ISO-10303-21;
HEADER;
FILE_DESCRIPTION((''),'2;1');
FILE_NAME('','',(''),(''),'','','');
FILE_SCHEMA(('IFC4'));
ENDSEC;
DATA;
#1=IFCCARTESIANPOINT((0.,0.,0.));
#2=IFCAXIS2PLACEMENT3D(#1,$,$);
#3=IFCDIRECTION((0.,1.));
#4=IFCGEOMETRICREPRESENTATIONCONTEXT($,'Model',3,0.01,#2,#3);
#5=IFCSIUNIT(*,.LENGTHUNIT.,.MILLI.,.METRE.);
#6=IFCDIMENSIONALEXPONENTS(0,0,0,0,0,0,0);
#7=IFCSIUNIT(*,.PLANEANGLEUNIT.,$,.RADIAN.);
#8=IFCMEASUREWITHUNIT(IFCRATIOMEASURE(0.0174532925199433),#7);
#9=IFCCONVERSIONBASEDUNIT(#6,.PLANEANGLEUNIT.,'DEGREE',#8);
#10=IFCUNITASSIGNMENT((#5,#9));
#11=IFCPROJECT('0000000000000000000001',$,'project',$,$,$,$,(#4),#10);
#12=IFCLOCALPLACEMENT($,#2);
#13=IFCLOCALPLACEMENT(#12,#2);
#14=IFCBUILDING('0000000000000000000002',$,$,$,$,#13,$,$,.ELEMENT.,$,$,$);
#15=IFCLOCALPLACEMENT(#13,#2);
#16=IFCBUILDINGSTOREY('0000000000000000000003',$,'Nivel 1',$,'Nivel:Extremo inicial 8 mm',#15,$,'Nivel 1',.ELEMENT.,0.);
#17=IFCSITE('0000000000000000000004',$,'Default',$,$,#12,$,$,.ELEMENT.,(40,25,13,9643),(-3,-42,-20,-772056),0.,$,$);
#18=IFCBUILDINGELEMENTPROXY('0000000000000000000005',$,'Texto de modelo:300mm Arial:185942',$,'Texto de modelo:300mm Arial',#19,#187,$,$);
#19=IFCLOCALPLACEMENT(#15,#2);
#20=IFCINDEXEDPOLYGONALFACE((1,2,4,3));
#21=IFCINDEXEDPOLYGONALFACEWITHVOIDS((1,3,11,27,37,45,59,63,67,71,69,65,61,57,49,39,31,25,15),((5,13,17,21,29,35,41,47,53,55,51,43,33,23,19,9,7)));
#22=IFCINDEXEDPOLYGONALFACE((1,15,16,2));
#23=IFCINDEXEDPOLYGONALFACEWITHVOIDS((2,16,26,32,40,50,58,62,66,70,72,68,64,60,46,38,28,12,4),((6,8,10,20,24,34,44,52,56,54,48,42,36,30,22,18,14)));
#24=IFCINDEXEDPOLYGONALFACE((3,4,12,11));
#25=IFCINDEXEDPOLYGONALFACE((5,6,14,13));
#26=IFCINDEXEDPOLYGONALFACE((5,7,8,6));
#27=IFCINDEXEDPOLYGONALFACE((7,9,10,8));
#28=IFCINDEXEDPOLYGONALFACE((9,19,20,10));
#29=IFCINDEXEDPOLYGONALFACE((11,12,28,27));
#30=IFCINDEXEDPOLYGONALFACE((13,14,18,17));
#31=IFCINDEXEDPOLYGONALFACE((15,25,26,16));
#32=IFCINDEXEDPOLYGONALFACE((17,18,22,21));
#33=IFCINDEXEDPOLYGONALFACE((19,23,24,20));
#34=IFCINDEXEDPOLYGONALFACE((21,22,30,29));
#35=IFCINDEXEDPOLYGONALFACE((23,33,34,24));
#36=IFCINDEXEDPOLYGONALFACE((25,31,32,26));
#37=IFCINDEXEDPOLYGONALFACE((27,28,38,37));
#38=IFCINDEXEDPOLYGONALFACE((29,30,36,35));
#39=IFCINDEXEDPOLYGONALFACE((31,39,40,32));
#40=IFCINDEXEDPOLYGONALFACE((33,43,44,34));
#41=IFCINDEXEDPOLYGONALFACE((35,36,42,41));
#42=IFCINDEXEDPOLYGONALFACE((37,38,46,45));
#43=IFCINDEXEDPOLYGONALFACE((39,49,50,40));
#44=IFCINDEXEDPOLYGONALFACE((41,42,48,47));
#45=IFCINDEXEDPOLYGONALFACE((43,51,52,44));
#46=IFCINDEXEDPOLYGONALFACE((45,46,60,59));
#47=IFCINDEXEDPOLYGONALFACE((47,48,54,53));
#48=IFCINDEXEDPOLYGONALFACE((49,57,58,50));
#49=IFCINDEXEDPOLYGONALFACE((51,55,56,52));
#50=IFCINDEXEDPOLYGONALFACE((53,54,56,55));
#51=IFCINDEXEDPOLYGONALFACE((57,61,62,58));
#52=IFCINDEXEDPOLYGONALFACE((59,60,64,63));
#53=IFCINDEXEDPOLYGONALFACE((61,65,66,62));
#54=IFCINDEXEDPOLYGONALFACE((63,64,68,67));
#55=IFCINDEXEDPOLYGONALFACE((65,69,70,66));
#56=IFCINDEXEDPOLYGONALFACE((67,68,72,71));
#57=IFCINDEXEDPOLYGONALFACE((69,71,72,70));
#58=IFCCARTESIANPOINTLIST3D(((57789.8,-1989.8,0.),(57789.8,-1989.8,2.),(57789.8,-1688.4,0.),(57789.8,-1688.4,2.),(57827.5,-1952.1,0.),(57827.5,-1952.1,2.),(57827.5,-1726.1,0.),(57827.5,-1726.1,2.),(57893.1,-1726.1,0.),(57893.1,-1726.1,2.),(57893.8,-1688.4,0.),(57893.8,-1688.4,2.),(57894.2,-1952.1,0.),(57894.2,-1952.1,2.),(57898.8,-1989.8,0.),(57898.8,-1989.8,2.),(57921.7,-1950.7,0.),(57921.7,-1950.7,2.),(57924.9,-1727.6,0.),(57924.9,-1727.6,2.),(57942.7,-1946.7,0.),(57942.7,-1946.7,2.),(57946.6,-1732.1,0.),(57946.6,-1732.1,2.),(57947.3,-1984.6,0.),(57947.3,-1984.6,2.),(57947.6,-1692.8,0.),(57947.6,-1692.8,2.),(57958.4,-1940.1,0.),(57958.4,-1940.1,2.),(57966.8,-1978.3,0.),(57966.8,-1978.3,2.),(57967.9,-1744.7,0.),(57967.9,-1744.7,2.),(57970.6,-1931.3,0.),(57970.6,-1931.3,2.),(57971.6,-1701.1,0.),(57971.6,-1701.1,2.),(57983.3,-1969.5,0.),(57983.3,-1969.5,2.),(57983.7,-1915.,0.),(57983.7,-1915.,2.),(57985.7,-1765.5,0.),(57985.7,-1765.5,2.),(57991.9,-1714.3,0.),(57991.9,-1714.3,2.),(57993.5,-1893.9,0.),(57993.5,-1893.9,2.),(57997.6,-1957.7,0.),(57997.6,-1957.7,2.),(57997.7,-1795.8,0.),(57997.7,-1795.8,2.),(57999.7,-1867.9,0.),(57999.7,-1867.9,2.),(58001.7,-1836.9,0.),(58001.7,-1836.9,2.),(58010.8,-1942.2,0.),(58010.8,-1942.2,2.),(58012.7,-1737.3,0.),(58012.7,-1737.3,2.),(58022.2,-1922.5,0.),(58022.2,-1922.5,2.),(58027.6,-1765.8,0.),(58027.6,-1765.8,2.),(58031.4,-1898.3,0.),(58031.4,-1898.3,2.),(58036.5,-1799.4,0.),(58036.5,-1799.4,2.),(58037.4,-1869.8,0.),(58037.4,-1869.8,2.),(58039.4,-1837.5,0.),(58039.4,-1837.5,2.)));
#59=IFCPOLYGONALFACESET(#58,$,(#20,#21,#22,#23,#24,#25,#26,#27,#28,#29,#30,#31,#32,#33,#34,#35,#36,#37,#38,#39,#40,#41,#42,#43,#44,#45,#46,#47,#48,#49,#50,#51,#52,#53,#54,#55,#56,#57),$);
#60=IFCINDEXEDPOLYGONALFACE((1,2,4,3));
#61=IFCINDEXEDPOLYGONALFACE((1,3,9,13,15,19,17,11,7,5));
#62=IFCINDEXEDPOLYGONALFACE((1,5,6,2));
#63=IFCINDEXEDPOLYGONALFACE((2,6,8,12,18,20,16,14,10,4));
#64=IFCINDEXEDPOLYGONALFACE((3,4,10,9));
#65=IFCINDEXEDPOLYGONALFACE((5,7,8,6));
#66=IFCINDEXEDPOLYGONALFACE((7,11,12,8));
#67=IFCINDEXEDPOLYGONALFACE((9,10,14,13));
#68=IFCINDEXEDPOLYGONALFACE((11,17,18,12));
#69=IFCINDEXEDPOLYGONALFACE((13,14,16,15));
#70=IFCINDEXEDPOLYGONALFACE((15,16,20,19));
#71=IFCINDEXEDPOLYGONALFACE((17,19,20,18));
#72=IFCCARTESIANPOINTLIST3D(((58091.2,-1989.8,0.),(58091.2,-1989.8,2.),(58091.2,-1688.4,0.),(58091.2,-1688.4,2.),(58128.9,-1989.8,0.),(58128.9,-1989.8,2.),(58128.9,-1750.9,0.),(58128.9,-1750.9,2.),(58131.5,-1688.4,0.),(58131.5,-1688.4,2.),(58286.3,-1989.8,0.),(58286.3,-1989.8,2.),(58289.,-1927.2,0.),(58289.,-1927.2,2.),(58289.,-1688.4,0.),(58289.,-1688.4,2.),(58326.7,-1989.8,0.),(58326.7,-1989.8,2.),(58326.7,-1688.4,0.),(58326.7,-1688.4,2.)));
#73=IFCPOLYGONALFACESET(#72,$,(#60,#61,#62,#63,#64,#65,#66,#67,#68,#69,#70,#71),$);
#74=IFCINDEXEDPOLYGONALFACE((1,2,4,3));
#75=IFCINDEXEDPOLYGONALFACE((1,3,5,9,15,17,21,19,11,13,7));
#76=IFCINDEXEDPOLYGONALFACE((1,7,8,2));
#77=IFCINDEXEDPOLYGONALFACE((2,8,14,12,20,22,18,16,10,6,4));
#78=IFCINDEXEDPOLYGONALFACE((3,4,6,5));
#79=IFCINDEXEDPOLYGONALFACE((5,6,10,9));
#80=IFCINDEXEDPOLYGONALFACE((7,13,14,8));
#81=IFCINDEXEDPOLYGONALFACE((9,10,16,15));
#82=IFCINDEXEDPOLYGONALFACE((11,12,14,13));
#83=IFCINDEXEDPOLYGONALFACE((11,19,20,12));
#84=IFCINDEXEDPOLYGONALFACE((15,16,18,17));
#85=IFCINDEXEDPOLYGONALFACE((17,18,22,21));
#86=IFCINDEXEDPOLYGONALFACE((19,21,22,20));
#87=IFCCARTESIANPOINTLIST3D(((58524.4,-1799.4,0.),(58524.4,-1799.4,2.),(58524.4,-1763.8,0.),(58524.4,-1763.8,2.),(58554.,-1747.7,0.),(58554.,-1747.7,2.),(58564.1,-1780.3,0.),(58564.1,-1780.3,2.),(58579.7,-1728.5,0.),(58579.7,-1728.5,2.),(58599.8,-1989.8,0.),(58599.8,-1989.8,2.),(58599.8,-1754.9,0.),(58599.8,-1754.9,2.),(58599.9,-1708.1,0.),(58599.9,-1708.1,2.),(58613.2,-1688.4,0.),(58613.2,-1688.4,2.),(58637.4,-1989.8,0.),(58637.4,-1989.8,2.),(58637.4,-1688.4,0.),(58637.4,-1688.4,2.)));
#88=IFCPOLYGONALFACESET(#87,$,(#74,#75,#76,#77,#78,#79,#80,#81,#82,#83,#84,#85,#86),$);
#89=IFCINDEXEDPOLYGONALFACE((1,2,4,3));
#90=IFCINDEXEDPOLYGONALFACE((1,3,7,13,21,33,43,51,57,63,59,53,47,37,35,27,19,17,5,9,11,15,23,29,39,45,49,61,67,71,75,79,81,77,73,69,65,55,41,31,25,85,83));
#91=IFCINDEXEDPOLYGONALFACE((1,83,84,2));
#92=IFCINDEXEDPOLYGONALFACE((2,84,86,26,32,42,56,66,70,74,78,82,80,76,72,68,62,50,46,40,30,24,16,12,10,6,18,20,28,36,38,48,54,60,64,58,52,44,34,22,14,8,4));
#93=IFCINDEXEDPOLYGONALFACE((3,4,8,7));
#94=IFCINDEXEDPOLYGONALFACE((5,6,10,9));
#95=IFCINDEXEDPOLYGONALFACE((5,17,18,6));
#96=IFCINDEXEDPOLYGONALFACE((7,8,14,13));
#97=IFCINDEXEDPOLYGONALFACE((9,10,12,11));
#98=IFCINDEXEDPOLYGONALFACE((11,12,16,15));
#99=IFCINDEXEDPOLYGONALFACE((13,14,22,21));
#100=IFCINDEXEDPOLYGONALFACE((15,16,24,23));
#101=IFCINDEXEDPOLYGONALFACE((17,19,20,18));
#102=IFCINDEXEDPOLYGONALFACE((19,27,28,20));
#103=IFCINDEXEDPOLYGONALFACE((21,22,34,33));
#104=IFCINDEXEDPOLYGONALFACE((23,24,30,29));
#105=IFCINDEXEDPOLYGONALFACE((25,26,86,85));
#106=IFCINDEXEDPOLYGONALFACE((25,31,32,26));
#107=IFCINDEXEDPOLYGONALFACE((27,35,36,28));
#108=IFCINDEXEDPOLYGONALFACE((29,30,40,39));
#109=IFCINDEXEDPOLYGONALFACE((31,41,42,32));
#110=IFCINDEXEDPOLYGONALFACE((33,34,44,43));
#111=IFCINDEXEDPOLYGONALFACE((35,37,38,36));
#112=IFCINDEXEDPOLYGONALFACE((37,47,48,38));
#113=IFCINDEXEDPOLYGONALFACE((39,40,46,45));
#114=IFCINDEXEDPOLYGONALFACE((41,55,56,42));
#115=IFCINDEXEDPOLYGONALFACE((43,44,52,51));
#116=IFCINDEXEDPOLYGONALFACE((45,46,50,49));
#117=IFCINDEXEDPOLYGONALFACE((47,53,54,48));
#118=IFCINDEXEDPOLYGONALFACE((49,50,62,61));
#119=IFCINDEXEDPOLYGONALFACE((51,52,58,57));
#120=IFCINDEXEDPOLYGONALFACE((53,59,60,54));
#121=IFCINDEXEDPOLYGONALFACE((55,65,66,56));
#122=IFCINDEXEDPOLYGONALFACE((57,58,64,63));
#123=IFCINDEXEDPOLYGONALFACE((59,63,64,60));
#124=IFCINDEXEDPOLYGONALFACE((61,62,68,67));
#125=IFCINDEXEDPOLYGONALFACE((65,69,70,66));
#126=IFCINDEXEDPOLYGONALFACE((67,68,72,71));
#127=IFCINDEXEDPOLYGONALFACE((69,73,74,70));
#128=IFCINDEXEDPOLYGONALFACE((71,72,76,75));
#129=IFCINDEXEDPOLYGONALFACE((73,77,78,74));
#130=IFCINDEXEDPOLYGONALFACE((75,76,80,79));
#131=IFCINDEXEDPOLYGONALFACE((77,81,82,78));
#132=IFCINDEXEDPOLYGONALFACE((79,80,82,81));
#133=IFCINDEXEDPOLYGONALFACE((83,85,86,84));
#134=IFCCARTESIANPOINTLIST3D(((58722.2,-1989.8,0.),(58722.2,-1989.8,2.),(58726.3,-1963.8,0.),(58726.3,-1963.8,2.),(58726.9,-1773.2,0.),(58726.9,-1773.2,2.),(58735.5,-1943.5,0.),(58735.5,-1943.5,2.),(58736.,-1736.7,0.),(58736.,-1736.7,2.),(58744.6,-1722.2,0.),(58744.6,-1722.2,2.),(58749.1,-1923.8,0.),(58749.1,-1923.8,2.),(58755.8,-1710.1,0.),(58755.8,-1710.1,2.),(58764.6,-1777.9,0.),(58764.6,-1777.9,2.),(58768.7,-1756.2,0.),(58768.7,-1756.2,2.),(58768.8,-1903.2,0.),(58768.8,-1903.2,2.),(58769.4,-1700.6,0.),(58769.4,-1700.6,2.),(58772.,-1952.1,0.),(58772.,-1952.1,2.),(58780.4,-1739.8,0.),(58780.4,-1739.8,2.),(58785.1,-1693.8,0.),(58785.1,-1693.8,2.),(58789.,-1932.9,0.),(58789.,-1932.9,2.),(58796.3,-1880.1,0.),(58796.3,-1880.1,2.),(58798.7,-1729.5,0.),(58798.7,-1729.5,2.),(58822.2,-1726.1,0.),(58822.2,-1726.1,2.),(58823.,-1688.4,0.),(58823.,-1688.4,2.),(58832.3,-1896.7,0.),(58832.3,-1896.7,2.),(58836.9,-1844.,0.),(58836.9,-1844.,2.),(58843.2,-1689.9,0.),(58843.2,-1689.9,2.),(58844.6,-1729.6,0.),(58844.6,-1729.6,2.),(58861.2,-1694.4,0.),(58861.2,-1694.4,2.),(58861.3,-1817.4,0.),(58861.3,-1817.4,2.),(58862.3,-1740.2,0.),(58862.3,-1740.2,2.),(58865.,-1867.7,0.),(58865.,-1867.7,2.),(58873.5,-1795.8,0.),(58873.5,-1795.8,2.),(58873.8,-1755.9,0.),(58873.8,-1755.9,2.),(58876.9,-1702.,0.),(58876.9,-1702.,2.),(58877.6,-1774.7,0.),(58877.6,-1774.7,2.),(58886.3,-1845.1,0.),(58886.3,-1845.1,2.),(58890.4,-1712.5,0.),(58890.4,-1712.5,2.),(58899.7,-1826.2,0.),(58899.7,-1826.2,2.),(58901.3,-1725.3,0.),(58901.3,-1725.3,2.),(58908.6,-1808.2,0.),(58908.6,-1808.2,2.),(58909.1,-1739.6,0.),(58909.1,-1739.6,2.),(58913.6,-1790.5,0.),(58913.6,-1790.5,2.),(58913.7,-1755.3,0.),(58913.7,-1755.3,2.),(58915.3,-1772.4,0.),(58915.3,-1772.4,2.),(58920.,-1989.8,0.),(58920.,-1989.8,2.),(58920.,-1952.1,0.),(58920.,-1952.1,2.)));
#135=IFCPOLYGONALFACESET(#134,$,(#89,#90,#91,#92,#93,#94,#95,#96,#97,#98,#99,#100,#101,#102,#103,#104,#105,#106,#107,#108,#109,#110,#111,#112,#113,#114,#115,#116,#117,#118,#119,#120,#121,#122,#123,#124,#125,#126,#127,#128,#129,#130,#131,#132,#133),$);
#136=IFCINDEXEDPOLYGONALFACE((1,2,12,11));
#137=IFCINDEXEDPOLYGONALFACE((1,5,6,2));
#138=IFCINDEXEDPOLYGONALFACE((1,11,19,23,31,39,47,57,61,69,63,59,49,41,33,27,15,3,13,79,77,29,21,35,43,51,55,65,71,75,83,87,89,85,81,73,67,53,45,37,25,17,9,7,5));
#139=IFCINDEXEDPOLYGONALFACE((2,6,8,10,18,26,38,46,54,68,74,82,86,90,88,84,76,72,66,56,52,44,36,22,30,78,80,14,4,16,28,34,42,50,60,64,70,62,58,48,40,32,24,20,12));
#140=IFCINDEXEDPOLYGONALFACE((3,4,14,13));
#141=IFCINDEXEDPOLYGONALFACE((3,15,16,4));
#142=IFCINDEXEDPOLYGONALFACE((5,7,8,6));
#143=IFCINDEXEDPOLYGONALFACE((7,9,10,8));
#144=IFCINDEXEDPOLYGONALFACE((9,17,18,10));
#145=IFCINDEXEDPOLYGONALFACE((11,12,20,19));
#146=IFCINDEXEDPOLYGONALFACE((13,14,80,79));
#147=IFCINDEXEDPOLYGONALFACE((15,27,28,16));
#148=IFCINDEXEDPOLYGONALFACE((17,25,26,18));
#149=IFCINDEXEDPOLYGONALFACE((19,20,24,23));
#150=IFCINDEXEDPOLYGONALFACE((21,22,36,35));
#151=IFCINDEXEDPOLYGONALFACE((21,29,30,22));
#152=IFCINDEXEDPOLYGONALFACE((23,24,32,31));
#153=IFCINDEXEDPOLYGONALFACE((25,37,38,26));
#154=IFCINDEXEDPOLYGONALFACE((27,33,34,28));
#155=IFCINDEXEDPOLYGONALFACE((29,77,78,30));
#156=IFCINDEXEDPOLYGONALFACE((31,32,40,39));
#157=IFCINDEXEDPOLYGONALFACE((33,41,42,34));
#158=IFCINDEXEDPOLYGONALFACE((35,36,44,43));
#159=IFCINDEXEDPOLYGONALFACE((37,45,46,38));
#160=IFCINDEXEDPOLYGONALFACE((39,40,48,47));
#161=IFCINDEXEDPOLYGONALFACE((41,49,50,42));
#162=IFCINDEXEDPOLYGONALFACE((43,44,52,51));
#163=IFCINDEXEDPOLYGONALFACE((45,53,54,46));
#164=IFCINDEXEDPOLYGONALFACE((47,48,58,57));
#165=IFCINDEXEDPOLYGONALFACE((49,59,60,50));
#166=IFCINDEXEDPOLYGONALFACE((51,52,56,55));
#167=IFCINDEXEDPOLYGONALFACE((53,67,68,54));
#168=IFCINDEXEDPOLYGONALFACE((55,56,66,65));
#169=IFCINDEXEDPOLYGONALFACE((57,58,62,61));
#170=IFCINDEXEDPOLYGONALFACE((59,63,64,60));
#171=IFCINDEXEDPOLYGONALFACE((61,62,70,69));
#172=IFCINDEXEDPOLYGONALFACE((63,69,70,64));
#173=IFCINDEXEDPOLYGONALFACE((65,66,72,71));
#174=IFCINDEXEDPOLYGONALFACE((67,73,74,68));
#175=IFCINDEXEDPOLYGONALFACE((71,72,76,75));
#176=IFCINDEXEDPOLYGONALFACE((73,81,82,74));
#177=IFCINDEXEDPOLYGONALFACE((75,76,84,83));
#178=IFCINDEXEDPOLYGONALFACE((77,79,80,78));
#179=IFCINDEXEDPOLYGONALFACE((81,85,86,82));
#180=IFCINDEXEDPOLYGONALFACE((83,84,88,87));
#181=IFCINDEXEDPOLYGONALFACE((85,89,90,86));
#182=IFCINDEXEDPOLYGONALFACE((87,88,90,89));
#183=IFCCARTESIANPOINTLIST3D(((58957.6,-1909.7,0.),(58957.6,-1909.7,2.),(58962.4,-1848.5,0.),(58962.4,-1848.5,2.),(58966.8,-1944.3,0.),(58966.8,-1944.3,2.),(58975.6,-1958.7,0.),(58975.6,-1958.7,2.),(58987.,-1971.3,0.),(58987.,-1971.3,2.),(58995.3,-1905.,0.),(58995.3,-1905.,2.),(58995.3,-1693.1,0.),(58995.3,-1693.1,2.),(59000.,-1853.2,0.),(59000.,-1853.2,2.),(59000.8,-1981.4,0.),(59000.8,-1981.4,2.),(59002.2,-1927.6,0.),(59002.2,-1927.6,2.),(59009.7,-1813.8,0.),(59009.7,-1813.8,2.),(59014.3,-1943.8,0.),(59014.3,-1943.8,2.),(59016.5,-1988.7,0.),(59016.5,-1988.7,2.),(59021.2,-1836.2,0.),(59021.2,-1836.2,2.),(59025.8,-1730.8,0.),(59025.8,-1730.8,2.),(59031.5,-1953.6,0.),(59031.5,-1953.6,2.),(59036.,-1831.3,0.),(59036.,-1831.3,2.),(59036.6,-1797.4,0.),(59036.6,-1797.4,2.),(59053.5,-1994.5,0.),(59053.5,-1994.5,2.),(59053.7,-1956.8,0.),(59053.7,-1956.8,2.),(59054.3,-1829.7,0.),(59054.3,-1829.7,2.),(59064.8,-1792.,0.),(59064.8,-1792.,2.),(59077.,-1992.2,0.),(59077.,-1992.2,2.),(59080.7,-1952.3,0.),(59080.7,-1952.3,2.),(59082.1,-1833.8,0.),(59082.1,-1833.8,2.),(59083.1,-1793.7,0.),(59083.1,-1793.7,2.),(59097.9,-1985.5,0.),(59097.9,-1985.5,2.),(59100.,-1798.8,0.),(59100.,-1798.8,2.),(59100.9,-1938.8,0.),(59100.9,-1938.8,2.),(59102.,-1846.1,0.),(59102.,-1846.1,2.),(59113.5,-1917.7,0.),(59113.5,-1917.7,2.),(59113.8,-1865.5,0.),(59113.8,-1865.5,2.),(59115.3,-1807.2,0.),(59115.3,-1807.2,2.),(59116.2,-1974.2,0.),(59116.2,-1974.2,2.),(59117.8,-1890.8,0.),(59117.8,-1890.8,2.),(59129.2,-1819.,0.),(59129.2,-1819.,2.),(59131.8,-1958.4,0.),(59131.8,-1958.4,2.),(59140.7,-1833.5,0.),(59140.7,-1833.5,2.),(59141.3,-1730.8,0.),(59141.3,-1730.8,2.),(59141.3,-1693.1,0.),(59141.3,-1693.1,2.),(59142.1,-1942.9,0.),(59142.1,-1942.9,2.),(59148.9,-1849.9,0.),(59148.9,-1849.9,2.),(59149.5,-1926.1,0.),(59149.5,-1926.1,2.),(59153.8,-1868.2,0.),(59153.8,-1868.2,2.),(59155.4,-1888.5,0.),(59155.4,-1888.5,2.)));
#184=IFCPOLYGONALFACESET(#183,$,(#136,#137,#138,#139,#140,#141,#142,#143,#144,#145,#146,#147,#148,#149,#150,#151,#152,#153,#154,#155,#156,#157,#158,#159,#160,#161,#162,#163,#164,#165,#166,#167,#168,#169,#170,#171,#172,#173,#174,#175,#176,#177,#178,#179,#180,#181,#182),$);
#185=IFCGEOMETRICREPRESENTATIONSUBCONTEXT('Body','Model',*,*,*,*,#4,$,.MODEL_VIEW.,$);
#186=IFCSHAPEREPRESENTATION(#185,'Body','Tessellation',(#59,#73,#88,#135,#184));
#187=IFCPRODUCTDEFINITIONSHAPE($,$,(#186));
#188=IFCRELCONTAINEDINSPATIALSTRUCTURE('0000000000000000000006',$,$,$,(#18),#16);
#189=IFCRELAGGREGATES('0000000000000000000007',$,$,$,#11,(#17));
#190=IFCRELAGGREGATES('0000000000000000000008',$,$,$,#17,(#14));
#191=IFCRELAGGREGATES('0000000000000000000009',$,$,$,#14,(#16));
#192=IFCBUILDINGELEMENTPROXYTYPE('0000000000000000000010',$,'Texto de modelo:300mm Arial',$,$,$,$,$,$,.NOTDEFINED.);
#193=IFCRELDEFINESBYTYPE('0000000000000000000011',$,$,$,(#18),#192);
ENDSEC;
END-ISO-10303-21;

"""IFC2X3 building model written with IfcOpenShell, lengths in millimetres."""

from ifc_helpers import new_model, entity, si_unit, converted_unit, direction, frame, origin, place, context, subcontext, project, spatial, polyline, outline, extrude, type_object, element, save


model = new_model("IFC2X3")

# Units and contexts
model_context = context("Model", 3, precision=0.01, world=origin(), true_north=direction((0.0, 1.0)))
body_context = subcontext(model_context, "Body", "Model", "MODEL_VIEW")
ifc_project = project(units=[si_unit("LENGTHUNIT", "METRE", prefix="MILLI"), converted_unit("PLANEANGLEUNIT", "DEGREE", entity("IfcRatioMeasure", 0.0174532925199433), si_unit("PLANEANGLEUNIT", "RADIAN"), dimensions=[0, 0, 0, 0, 0, 0, 0])], contexts=[model_context])

# Site, building, storey
site_placement = place(None, origin())
site = spatial("IfcSite", under=ifc_project, at=site_placement, Name="Default", CompositionType="ELEMENT", RefLatitude=(40, 25, 13, 9643), RefLongitude=(-3, -42, -20, -772056), RefElevation=0.0)
building_placement = place(site_placement, origin())
building = spatial("IfcBuilding", under=site, at=building_placement, CompositionType="ELEMENT")
storey_placement = place(building_placement, origin())
storey = spatial("IfcBuildingStorey", under=building, at=storey_placement, Name="Nivel 1", ObjectType="Nivel:Extremo inicial 8 mm", LongName="Nivel 1", CompositionType="ELEMENT", Elevation=0.0)

# Building element proxy
building_element_proxy_type_1 = type_object("IfcBuildingElementProxyType", Name="Texto de modelo:300mm Arial", PredefinedType="NOTDEFINED")
proxy_1_placement = place(storey_placement, frame((57789.8, -1994.5, 0.0)))
element("IfcBuildingElementProxy", 1, at=proxy_1_placement, inside=storey, type_object=building_element_proxy_type_1, Name="Texto de modelo:300mm Arial:185942", ObjectType="Texto de modelo:300mm Arial", context=body_context, shape_type="SweptSolid", body=[
    extrude(outline(polyline([(-178.4, -141.0), (-69.4, -141.0), (-21.0, -135.8), (-1.4, -129.5), (15.0, -120.7), (29.4, -108.9), (42.6, -93.4), (54.0, -73.7), (63.2, -49.5), (69.2, -21.0), (71.2, 11.3), (68.2, 49.4), (59.3, 83.0), (44.5, 111.5), (23.7, 134.5), (3.4, 147.7), (-20.6, 156.1), (-74.4, 160.4), (-178.4, 160.4), (-178.4, -141.0)]), holes=[polyline([(-140.7, -103.3), (-140.7, 122.7), (-75.1, 122.7), (-43.3, 121.2), (-21.7, 116.7), (-0.4, 104.1), (17.4, 83.3), (29.5, 53.0), (33.5, 11.9), (31.5, -19.1), (25.3, -45.1), (15.5, -66.2), (2.4, -82.5), (-9.8, -91.3), (-25.6, -97.9), (-46.5, -101.9), (-74.1, -103.3), (-140.7, -103.3)])]), frame((178.4, 145.7, 0.0)), (0.0, 0.0, 1.0), 2.0),
    extrude(outline(polyline([(-117.7, -150.7), (-80.1, -150.7), (-80.1, 88.1), (77.4, -150.7), (117.7, -150.7), (117.7, 150.7), (80.1, 150.7), (80.1, -88.1), (-77.4, 150.7), (-117.7, 150.7), (-117.7, -150.7)])), frame((419.1, 155.4, 0.0)), (0.0, 0.0, 1.0), 2.0),
    extrude(outline(polyline([(-204.4, -52.5), (97.0, -52.5), (97.0, -28.2), (77.2, -14.9), (56.9, 5.3), (37.7, 30.9), (21.6, 60.5), (-14.0, 60.5), (5.0, 20.8), (30.4, -14.9), (-204.4, -14.9), (-204.4, -52.5)])), frame((795.1, 209.1, 0.0), z_axis=(0.0, 0.0, 1.0), x_axis=(0.0, 1.0, 0.0)), (0.0, 0.0, 1.0), 2.0),
    extrude(outline(polyline([(-91.6, -150.5), (-91.6, -188.2), (106.2, -188.2), (102.1, -162.2), (92.9, -141.9), (79.3, -122.2), (59.6, -101.6), (32.1, -78.5), (-8.5, -42.4), (-32.9, -15.8), (-45.1, 5.8), (-49.2, 26.9), (-45.4, 45.8), (-33.9, 61.4), (-16.2, 72.0), (6.2, 75.5), (29.7, 72.1), (48.0, 61.8), (59.7, 45.4), (63.8, 23.7), (101.5, 28.4), (92.4, 64.9), (83.8, 79.4), (72.6, 91.5), (59.0, 101.0), (43.3, 107.8), (5.4, 113.2), (-14.8, 111.7), (-32.8, 107.2), (-48.5, 99.6), (-62.0, 89.1), (-72.9, 76.3), (-80.7, 62.0), (-85.3, 46.3), (-86.9, 29.2), (-85.2, 11.2), (-80.2, -6.5), (-71.3, -24.6), (-57.9, -43.5), (-36.6, -66.1), (-3.9, -95.1), (39.4, -131.3), (56.4, -150.5), (-91.6, -150.5)])), frame((1038.6, 192.9, 0.0), z_axis=(0.0, 0.0, -1.0), x_axis=(-1.0, 0.0, 0.0)), (0.0, 0.0, -1.0), 2.0),
    extrude(outline(polyline([(1.4, -113.1), (37.2, -113.1), (53.4, -108.4), (68.5, -100.5), (81.8, -89.8), (92.9, -76.5), (108.0, -42.2), (111.8, -18.9), (110.6, 3.0), (104.4, 23.5), (93.2, 42.7), (80.9, 56.7), (66.6, 68.1), (31.7, 83.5), (11.7, 87.1), (-7.3, 87.1), (-25.2, 83.4), (-42.2, 76.0), (-57.1, 65.7), (-69.2, 53.0), (-78.5, 38.0), (-84.8, 20.7), (-86.8, -7.9), (-77.9, -38.1), (-154.0, -1.2), (-124.3, 110.4), (-160.7, 120.1), (-198.2, -21.0), (-56.5, -92.8), (-42.3, -57.6), (-53.3, -32.8), (-54.2, -17.2), (-51.1, 0.9), (-40.0, 26.8), (-23.0, 42.8), (-1.2, 49.2), (24.3, 46.5), (49.2, 35.5), (66.3, 17.9), (74.2, -5.1), (71.6, -32.4), (62.8, -53.0), (48.9, -67.1), (30.2, -74.6), (6.6, -75.5), (1.4, -113.1)])), frame((1276.7, 115.2, 0.0), z_axis=(0.0, 0.0, 1.0), x_axis=(0.256974, -0.966418, 0.0)), (0.0, 0.0, 1.0), 2.0),
])

save(model, "model.ifc")
